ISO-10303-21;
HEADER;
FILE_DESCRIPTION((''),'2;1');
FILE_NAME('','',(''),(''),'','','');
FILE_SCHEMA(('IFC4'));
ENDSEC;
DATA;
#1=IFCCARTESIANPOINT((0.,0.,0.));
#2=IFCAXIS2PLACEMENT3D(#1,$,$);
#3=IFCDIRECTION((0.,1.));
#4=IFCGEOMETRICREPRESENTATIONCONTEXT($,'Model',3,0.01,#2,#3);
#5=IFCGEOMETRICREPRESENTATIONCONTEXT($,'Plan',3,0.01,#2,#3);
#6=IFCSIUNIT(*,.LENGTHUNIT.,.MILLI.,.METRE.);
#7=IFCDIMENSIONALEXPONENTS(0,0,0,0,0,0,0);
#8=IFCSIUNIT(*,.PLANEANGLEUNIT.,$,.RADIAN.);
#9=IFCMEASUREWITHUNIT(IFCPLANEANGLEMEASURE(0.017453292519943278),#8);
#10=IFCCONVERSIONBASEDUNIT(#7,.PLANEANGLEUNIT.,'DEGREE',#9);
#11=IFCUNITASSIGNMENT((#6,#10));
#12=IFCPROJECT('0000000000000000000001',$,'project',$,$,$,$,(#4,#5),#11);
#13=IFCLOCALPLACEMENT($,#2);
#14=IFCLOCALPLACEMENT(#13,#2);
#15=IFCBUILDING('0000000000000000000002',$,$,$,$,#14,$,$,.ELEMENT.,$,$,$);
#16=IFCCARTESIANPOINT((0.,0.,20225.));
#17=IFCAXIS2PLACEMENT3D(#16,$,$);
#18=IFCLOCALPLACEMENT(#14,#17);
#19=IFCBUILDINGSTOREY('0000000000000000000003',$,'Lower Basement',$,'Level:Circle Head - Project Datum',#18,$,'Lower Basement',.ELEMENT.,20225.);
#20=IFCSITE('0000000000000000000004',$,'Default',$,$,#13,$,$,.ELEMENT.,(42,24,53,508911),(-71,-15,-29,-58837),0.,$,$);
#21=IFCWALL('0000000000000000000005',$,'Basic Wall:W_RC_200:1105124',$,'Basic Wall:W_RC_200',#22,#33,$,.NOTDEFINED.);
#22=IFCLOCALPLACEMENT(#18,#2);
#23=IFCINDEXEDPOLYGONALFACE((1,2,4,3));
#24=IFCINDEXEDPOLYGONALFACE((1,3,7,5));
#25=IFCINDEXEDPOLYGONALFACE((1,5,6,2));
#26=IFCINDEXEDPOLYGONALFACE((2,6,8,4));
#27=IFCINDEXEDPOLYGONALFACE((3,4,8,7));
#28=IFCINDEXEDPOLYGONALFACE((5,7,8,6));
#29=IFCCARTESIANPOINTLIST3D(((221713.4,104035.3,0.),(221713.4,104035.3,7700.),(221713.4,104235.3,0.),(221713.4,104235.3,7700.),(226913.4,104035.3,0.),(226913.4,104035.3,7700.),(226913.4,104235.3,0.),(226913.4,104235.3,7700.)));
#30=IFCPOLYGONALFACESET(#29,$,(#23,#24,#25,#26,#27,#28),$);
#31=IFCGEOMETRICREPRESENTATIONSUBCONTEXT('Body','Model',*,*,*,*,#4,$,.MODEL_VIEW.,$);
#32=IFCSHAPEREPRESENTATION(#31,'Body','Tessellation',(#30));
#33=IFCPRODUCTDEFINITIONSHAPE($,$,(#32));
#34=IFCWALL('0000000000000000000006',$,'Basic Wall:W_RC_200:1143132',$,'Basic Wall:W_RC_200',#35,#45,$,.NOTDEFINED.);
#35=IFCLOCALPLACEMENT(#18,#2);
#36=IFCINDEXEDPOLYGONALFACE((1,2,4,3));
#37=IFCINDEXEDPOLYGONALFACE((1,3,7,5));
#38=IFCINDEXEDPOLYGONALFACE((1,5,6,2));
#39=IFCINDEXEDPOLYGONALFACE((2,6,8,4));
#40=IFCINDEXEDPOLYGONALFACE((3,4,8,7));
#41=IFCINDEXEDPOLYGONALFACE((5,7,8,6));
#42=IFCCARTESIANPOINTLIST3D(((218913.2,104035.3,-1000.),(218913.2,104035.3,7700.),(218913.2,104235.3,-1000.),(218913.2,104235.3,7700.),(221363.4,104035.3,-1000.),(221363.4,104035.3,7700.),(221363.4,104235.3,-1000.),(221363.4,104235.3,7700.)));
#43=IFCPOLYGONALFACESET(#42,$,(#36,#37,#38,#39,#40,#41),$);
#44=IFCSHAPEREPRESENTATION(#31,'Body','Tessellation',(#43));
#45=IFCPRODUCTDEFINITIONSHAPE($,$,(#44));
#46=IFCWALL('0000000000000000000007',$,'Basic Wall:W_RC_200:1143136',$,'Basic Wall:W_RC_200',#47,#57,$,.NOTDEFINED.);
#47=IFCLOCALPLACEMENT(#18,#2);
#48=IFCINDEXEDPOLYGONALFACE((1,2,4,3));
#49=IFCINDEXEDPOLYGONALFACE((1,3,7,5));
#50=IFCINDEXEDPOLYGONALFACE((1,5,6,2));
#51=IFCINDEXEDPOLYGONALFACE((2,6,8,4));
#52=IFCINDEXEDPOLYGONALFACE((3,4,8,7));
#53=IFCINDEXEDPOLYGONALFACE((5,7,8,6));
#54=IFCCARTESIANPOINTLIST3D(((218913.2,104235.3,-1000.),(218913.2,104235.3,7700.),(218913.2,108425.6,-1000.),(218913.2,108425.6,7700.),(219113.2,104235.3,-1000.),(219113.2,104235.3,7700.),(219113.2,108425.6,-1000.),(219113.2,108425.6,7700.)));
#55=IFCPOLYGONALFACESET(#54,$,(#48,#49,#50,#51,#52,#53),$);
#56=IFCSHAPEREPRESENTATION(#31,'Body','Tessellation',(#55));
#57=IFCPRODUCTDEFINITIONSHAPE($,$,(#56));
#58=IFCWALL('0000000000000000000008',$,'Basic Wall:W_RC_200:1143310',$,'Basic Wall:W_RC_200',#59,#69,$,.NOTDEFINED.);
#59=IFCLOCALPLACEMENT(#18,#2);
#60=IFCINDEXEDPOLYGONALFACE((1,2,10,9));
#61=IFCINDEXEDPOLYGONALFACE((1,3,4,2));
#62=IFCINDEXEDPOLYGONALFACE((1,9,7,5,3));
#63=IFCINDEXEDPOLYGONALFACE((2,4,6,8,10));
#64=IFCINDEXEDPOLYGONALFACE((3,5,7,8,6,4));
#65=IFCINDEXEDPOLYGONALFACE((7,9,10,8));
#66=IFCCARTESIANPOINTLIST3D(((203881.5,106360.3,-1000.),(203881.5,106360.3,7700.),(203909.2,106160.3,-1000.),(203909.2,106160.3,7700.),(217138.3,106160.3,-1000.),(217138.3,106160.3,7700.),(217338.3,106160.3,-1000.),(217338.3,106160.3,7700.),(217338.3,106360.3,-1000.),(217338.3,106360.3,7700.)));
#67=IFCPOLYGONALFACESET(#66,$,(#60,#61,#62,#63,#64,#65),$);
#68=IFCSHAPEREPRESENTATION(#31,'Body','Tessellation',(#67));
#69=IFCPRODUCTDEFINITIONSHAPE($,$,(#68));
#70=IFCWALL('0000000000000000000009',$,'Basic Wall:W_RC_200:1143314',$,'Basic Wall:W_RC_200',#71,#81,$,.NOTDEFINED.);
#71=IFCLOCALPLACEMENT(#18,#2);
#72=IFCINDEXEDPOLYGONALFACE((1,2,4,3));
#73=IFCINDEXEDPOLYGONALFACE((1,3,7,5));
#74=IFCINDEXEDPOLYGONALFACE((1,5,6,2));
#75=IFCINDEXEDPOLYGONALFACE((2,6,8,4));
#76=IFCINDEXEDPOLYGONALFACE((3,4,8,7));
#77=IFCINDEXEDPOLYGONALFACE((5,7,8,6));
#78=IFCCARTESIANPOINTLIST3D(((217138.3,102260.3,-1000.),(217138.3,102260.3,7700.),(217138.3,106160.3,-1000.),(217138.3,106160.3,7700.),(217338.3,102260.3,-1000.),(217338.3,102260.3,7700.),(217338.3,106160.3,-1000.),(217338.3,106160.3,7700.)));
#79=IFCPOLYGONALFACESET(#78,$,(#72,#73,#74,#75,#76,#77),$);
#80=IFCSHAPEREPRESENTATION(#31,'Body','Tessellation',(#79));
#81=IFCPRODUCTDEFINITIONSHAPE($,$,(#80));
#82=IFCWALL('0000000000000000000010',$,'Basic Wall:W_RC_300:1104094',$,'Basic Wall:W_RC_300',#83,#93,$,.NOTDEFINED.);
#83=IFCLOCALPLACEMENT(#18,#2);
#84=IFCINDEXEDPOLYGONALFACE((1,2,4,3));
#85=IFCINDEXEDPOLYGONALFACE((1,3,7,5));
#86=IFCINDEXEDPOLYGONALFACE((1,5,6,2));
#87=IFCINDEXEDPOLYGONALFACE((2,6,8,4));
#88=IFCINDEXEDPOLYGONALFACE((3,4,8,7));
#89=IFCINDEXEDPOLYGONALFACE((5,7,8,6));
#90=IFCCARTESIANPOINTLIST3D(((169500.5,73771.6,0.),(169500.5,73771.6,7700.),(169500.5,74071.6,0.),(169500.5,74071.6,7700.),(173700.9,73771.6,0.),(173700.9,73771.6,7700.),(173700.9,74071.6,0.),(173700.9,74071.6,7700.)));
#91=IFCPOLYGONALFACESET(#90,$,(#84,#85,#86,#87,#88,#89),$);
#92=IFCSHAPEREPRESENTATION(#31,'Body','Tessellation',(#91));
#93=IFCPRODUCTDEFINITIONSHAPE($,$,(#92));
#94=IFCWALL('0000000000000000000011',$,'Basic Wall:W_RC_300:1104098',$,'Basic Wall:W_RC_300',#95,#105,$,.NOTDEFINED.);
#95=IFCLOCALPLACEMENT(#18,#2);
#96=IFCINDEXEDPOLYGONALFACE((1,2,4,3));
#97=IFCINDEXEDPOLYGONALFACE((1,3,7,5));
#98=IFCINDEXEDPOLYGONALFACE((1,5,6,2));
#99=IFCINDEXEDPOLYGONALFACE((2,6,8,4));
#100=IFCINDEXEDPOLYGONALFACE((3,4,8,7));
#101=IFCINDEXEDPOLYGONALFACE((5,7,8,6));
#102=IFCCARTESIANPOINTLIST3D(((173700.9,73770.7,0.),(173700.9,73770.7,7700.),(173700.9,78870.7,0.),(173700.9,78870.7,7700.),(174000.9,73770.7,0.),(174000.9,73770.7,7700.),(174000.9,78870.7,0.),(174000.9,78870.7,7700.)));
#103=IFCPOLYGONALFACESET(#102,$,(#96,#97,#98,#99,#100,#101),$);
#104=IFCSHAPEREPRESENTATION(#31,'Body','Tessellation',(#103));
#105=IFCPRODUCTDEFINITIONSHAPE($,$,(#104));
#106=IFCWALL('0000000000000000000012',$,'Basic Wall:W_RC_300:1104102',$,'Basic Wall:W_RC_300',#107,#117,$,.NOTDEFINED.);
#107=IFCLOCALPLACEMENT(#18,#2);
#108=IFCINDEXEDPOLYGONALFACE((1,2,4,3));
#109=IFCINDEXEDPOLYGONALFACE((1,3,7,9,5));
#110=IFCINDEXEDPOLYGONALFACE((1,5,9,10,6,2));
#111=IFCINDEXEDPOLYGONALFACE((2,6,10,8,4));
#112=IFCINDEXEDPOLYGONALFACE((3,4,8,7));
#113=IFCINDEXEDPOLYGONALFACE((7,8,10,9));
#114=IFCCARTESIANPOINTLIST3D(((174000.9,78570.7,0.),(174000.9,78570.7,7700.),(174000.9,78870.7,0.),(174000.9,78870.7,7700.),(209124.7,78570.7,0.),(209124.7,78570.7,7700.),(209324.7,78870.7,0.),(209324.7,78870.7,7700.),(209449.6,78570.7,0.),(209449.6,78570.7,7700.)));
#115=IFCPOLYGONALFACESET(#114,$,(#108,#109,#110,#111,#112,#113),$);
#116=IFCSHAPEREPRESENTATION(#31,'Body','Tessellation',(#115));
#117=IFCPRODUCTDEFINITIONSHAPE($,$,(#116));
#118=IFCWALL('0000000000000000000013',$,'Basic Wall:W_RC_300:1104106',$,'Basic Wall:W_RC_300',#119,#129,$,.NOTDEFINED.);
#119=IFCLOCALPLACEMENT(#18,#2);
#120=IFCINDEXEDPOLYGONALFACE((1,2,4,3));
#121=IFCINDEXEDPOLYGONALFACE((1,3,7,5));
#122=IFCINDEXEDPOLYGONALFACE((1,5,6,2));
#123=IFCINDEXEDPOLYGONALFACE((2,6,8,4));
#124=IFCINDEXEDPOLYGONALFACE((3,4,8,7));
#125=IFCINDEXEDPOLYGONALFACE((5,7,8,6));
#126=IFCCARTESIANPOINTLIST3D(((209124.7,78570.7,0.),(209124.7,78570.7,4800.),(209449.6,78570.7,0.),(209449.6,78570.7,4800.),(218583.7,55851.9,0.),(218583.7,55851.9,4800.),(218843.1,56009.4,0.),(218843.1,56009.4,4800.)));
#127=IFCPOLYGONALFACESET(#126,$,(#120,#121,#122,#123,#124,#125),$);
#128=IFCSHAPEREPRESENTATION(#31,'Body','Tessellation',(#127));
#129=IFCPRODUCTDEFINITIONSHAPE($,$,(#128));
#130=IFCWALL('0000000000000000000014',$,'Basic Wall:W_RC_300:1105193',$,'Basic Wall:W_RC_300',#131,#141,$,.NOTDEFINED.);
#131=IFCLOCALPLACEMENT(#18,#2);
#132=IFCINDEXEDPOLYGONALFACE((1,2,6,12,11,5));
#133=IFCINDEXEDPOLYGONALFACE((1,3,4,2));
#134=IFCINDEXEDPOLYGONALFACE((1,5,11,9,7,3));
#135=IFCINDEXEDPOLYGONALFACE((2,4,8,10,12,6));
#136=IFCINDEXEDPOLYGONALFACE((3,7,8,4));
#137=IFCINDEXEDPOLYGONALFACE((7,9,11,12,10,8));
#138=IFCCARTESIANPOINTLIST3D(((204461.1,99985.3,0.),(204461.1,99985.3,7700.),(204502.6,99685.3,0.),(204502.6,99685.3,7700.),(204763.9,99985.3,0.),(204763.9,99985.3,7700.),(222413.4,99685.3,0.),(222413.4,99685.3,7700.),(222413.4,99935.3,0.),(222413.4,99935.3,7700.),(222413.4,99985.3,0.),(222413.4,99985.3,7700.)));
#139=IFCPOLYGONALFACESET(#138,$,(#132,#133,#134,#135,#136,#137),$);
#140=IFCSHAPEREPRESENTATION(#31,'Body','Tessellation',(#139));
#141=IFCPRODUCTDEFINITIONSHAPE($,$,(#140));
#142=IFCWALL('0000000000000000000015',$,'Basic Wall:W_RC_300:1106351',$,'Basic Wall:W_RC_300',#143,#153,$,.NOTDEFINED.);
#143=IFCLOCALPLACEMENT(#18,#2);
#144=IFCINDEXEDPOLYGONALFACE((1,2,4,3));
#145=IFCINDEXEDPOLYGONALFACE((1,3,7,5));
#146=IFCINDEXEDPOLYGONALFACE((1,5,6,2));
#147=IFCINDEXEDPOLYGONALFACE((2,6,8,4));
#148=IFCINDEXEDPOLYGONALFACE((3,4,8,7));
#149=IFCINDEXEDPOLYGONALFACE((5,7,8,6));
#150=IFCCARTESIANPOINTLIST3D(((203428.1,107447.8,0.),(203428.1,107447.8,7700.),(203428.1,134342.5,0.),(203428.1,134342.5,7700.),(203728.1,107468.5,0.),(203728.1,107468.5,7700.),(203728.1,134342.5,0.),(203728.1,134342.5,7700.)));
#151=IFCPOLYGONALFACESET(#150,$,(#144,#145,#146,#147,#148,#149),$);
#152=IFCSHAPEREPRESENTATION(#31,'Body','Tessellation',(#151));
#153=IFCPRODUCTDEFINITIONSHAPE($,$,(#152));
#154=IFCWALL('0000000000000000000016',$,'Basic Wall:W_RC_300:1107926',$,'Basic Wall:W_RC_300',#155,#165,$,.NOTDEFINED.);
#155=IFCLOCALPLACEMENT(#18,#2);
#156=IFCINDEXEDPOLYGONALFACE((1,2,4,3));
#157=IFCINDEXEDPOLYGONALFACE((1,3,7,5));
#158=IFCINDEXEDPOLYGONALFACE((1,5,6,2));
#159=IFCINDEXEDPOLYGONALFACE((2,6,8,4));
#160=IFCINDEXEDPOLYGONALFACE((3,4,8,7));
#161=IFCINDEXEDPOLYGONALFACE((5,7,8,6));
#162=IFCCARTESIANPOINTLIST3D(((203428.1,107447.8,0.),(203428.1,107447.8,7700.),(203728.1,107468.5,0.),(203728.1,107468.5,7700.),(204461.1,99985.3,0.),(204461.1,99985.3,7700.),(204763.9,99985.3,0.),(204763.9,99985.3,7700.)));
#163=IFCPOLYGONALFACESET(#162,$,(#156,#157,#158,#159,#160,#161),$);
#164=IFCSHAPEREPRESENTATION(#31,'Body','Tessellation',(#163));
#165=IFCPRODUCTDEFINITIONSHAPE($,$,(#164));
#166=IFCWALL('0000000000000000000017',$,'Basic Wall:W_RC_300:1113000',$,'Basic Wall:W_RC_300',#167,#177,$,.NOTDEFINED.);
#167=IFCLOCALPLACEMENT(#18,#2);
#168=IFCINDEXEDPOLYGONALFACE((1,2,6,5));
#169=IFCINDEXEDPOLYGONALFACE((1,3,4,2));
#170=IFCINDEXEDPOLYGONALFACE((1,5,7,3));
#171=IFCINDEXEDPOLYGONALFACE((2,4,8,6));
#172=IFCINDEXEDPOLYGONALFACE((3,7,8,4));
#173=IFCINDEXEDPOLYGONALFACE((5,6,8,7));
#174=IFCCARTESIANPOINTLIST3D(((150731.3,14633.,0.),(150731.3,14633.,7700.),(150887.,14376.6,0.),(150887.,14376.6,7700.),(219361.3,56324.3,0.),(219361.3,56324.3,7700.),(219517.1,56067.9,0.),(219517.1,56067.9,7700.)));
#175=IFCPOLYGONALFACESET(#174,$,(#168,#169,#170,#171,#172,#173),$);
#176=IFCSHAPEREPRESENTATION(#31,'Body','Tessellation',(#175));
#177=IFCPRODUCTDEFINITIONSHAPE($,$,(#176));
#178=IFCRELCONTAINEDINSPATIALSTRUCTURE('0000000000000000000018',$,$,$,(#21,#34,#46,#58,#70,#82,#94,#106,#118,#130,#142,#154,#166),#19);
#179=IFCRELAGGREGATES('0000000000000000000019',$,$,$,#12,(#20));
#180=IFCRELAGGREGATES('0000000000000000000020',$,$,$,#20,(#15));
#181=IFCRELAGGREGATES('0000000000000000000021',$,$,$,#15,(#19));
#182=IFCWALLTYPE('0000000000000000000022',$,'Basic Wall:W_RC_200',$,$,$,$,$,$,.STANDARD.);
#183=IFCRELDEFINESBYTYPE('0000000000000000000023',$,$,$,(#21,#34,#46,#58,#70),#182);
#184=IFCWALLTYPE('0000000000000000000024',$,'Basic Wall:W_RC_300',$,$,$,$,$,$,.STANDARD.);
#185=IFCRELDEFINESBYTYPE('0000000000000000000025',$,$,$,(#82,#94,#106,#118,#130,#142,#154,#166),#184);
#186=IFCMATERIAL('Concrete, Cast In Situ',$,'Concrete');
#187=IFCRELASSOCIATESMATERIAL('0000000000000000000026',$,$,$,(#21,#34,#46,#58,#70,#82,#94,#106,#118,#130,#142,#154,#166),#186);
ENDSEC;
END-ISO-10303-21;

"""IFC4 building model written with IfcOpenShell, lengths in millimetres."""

from ifc_helpers import new_model, entity, si_unit, converted_unit, direction, frame, origin, place, context, subcontext, project, spatial, indexed_curve, outline, extrude, material, type_object, element, save


model = new_model("IFC4")

# Units and contexts
model_context = context("Model", 3, precision=0.01, world=origin(), true_north=direction((0.0, 1.0)))
plan_context = context("Plan", 3, precision=0.01, world=origin(), true_north=direction((0.0, 1.0)))
body_context = subcontext(model_context, "Body", "Model", "MODEL_VIEW")
ifc_project = project(units=[si_unit("LENGTHUNIT", "METRE", prefix="MILLI"), converted_unit("PLANEANGLEUNIT", "DEGREE", entity("IfcPlaneAngleMeasure", 0.017453292519943278), si_unit("PLANEANGLEUNIT", "RADIAN"), dimensions=[0, 0, 0, 0, 0, 0, 0])], contexts=[model_context, plan_context])

# Site, building, storey
site_placement = place(None, origin())
site = spatial("IfcSite", under=ifc_project, at=site_placement, Name="Default", CompositionType="ELEMENT", RefLatitude=(42, 24, 53, 508911), RefLongitude=(-71, -15, -29, -58837), RefElevation=0.0)
building_placement = place(site_placement, origin())
building = spatial("IfcBuilding", under=site, at=building_placement, CompositionType="ELEMENT")
storey_placement = place(building_placement, frame((0.0, 0.0, 20225.0)))
storey = spatial("IfcBuildingStorey", under=building, at=storey_placement, Name="Lower Basement", ObjectType="Level:Circle Head - Project Datum", LongName="Lower Basement", CompositionType="ELEMENT", Elevation=20225.0)

# Walls
ifc_material_1 = material(Name="Concrete, Cast In Situ", Category="Concrete")
wall_type_1 = type_object("IfcWallType", Name="Basic Wall:W_RC_200", PredefinedType="STANDARD")
wall_1_placement = place(storey_placement, frame((221713.4, 104135.3, 0.0)))
element("IfcWall", 1, at=wall_1_placement, inside=storey, type_object=wall_type_1, material=ifc_material_1, Name="Basic Wall:W_RC_200:1105124", ObjectType="Basic Wall:W_RC_200", PredefinedType="NOTDEFINED", context=body_context, shape_type="SweptSolid", body=[
    extrude(outline(indexed_curve([(5200.0, 100.0), (0.0, 100.0), (0.0, -100.0), (5200.0, -100.0), (5200.0, 100.0)], self_intersect=False)), origin(), (0.0, 0.0, 1.0), 7700.0),
])
wall_2_placement = place(storey_placement, frame((218913.2, 104135.3, -1000.0)))
element("IfcWall", 2, at=wall_2_placement, inside=storey, type_object=wall_type_1, material=ifc_material_1, Name="Basic Wall:W_RC_200:1143132", ObjectType="Basic Wall:W_RC_200", PredefinedType="NOTDEFINED", context=body_context, shape_type="SweptSolid", body=[
    extrude(outline(indexed_curve([(2450.1, 100.0), (0.0, 100.0), (0.0, -100.0), (2450.1, -100.0), (2450.1, 100.0)], self_intersect=False)), origin(), (0.0, 0.0, 1.0), 8700.0),
])
wall_3_placement = place(storey_placement, frame((219013.2, 108425.6, -1000.0), z_axis=(0.0, 0.0, 1.0), x_axis=(0.0, -1.0, 0.0)))
element("IfcWall", 3, at=wall_3_placement, inside=storey, type_object=wall_type_1, material=ifc_material_1, Name="Basic Wall:W_RC_200:1143136", ObjectType="Basic Wall:W_RC_200", PredefinedType="NOTDEFINED", context=body_context, shape_type="SweptSolid", body=[
    extrude(outline(indexed_curve([(4190.2, 100.0), (0.0, 100.0), (0.0, -100.0), (4190.2, -100.0), (4190.2, 100.0)], self_intersect=False)), origin(), (0.0, 0.0, 1.0), 8700.0),
])
wall_4_placement = place(storey_placement, frame((203881.5, 106260.3, -1000.0)))
element("IfcWall", 4, at=wall_4_placement, inside=storey, type_object=wall_type_1, material=ifc_material_1, Name="Basic Wall:W_RC_200:1143310", ObjectType="Basic Wall:W_RC_200", PredefinedType="NOTDEFINED", context=body_context, shape_type="SweptSolid", body=[
    extrude(outline(indexed_curve([(13456.8, -100.0), (13456.8, 100.0), (0.0, 100.0), (27.7, -100.0), (13256.8, -100.0), (13456.8, -100.0)], self_intersect=False)), origin(), (0.0, 0.0, 1.0), 8700.0),
])
wall_5_placement = place(storey_placement, frame((217238.3, 106160.3, -1000.0), z_axis=(0.0, 0.0, 1.0), x_axis=(0.0, -1.0, 0.0)))
element("IfcWall", 5, at=wall_5_placement, inside=storey, type_object=wall_type_1, material=ifc_material_1, Name="Basic Wall:W_RC_200:1143314", ObjectType="Basic Wall:W_RC_200", PredefinedType="NOTDEFINED", context=body_context, shape_type="SweptSolid", body=[
    extrude(outline(indexed_curve([(3900.0, 100.0), (0.0, 100.0), (0.0, -100.0), (3900.0, -100.0), (3900.0, 100.0)], self_intersect=False)), origin(), (0.0, 0.0, 1.0), 8700.0),
])
wall_type_2 = type_object("IfcWallType", Name="Basic Wall:W_RC_300", PredefinedType="STANDARD")
wall_6_placement = place(storey_placement, frame((173700.9, 73921.6, 0.0), z_axis=(0.0, 0.0, 1.0), x_axis=(-1.0, 0.0, 0.0)))
element("IfcWall", 6, at=wall_6_placement, inside=storey, type_object=wall_type_2, material=ifc_material_1, Name="Basic Wall:W_RC_300:1104094", ObjectType="Basic Wall:W_RC_300", PredefinedType="NOTDEFINED", context=body_context, shape_type="SweptSolid", body=[
    extrude(outline(indexed_curve([(4200.4, 150.0), (0.0, 150.0), (0.0, -150.0), (4200.4, -150.0), (4200.4, 150.0)], self_intersect=False)), origin(), (0.0, 0.0, 1.0), 7700.0),
])
wall_7_placement = place(storey_placement, frame((173850.9, 78870.7, 0.0), z_axis=(0.0, 0.0, 1.0), x_axis=(0.0, -1.0, 0.0)))
element("IfcWall", 7, at=wall_7_placement, inside=storey, type_object=wall_type_2, material=ifc_material_1, Name="Basic Wall:W_RC_300:1104098", ObjectType="Basic Wall:W_RC_300", PredefinedType="NOTDEFINED", context=body_context, shape_type="SweptSolid", body=[
    extrude(outline(indexed_curve([(5099.9, 150.0), (0.0, 150.0), (0.0, -150.0), (5099.9, -150.0), (5099.9, 150.0)], self_intersect=False)), origin(), (0.0, 0.0, 1.0), 7700.0),
])
wall_8_placement = place(storey_placement, frame((209449.6, 78720.7, 0.0), z_axis=(0.0, 0.0, 1.0), x_axis=(-1.0, 0.0, 0.0)))
element("IfcWall", 8, at=wall_8_placement, inside=storey, type_object=wall_type_2, material=ifc_material_1, Name="Basic Wall:W_RC_300:1104102", ObjectType="Basic Wall:W_RC_300", PredefinedType="NOTDEFINED", context=body_context, shape_type="SweptSolid", body=[
    extrude(outline(indexed_curve([(35448.8, -150.0), (35448.8, 150.0), (325.0, 150.0), (0.0, 150.0), (124.9, -150.0), (35448.8, -150.0)], self_intersect=False)), origin(), (0.0, 0.0, 1.0), 7700.0),
])
wall_9_placement = place(storey_placement, frame((218722.2, 55909.5, 0.0), z_axis=(0.0, 0.0, 1.0), x_axis=(-0.384369, 0.923179, 0.0)))
element("IfcWall", 9, at=wall_9_placement, inside=storey, type_object=wall_type_2, material=ifc_material_1, Name="Basic Wall:W_RC_300:1104106", ObjectType="Basic Wall:W_RC_300", PredefinedType="NOTDEFINED", context=body_context, shape_type="SweptSolid", body=[
    extrude(outline(indexed_curve([(24484.4, -150.0), (24609.3, 150.0), (0.0, 150.0), (45.8, -150.0), (24484.4, -150.0)], self_intersect=False)), origin(), (0.0, 0.0, 1.0), 4800.0),
])
wall_10_placement = place(storey_placement, frame((222413.4, 99835.3, 0.0), z_axis=(0.0, 0.0, 1.0), x_axis=(-1.0, 0.0, 0.0)))
element("IfcWall", 10, at=wall_10_placement, inside=storey, type_object=wall_type_2, material=ifc_material_1, Name="Basic Wall:W_RC_300:1105193", ObjectType="Basic Wall:W_RC_300", PredefinedType="NOTDEFINED", context=body_context, shape_type="SweptSolid", body=[
    extrude(outline(indexed_curve([(17952.3, -150.0), (17910.7, 150.0), (0.0, 150.0), (0.0, -100.0), (0.0, -150.0), (17649.4, -150.0), (17952.3, -150.0)], self_intersect=False)), origin(), (0.0, 0.0, 1.0), 7700.0),
])
wall_11_placement = place(storey_placement, frame((203578.1, 107447.8, 0.0), z_axis=(0.0, 0.0, 1.0), x_axis=(0.0, 1.0, 0.0)))
element("IfcWall", 11, at=wall_11_placement, inside=storey, type_object=wall_type_2, material=ifc_material_1, Name="Basic Wall:W_RC_300:1106351", ObjectType="Basic Wall:W_RC_300", PredefinedType="NOTDEFINED", context=body_context, shape_type="SweptSolid", body=[
    extrude(outline(indexed_curve([(26894.7, -150.0), (26894.7, 150.0), (0.0, 150.0), (20.7, -150.0), (26894.7, -150.0)], self_intersect=False)), origin(), (0.0, 0.0, 1.0), 7700.0),
])
wall_12_placement = place(storey_placement, frame((204615.4, 99964.8, 0.0), z_axis=(0.0, 0.0, 1.0), x_axis=(-0.137115, 0.990555, 0.0)))
element("IfcWall", 12, at=wall_12_placement, inside=storey, type_object=wall_type_2, material=ifc_material_1, Name="Basic Wall:W_RC_300:1107926", ObjectType="Basic Wall:W_RC_300", PredefinedType="NOTDEFINED", context=body_context, shape_type="SweptSolid", body=[
    extrude(outline(indexed_curve([(7554.5, -150.0), (7575.1, 150.0), (41.5, 150.0), (0.0, -150.0), (7554.5, -150.0)], self_intersect=False)), origin(), (0.0, 0.0, 1.0), 7700.0),
])
wall_13_placement = place(storey_placement, frame((219439.2, 56196.1, 0.0), z_axis=(0.0, 0.0, 1.0), x_axis=(-0.854661, -0.519187, 0.0)))
element("IfcWall", 13, at=wall_13_placement, inside=storey, type_object=wall_type_2, material=ifc_material_1, Name="Basic Wall:W_RC_300:1113000", ObjectType="Basic Wall:W_RC_300", PredefinedType="NOTDEFINED", context=body_context, shape_type="SweptSolid", body=[
    extrude(outline(indexed_curve([(80301.0, 150.0), (0.0, 150.0), (0.0, -150.0), (80301.0, -150.0), (80301.0, 150.0)], self_intersect=False)), origin(), (0.0, 0.0, 1.0), 7700.0),
])

save(model, "model.ifc")
